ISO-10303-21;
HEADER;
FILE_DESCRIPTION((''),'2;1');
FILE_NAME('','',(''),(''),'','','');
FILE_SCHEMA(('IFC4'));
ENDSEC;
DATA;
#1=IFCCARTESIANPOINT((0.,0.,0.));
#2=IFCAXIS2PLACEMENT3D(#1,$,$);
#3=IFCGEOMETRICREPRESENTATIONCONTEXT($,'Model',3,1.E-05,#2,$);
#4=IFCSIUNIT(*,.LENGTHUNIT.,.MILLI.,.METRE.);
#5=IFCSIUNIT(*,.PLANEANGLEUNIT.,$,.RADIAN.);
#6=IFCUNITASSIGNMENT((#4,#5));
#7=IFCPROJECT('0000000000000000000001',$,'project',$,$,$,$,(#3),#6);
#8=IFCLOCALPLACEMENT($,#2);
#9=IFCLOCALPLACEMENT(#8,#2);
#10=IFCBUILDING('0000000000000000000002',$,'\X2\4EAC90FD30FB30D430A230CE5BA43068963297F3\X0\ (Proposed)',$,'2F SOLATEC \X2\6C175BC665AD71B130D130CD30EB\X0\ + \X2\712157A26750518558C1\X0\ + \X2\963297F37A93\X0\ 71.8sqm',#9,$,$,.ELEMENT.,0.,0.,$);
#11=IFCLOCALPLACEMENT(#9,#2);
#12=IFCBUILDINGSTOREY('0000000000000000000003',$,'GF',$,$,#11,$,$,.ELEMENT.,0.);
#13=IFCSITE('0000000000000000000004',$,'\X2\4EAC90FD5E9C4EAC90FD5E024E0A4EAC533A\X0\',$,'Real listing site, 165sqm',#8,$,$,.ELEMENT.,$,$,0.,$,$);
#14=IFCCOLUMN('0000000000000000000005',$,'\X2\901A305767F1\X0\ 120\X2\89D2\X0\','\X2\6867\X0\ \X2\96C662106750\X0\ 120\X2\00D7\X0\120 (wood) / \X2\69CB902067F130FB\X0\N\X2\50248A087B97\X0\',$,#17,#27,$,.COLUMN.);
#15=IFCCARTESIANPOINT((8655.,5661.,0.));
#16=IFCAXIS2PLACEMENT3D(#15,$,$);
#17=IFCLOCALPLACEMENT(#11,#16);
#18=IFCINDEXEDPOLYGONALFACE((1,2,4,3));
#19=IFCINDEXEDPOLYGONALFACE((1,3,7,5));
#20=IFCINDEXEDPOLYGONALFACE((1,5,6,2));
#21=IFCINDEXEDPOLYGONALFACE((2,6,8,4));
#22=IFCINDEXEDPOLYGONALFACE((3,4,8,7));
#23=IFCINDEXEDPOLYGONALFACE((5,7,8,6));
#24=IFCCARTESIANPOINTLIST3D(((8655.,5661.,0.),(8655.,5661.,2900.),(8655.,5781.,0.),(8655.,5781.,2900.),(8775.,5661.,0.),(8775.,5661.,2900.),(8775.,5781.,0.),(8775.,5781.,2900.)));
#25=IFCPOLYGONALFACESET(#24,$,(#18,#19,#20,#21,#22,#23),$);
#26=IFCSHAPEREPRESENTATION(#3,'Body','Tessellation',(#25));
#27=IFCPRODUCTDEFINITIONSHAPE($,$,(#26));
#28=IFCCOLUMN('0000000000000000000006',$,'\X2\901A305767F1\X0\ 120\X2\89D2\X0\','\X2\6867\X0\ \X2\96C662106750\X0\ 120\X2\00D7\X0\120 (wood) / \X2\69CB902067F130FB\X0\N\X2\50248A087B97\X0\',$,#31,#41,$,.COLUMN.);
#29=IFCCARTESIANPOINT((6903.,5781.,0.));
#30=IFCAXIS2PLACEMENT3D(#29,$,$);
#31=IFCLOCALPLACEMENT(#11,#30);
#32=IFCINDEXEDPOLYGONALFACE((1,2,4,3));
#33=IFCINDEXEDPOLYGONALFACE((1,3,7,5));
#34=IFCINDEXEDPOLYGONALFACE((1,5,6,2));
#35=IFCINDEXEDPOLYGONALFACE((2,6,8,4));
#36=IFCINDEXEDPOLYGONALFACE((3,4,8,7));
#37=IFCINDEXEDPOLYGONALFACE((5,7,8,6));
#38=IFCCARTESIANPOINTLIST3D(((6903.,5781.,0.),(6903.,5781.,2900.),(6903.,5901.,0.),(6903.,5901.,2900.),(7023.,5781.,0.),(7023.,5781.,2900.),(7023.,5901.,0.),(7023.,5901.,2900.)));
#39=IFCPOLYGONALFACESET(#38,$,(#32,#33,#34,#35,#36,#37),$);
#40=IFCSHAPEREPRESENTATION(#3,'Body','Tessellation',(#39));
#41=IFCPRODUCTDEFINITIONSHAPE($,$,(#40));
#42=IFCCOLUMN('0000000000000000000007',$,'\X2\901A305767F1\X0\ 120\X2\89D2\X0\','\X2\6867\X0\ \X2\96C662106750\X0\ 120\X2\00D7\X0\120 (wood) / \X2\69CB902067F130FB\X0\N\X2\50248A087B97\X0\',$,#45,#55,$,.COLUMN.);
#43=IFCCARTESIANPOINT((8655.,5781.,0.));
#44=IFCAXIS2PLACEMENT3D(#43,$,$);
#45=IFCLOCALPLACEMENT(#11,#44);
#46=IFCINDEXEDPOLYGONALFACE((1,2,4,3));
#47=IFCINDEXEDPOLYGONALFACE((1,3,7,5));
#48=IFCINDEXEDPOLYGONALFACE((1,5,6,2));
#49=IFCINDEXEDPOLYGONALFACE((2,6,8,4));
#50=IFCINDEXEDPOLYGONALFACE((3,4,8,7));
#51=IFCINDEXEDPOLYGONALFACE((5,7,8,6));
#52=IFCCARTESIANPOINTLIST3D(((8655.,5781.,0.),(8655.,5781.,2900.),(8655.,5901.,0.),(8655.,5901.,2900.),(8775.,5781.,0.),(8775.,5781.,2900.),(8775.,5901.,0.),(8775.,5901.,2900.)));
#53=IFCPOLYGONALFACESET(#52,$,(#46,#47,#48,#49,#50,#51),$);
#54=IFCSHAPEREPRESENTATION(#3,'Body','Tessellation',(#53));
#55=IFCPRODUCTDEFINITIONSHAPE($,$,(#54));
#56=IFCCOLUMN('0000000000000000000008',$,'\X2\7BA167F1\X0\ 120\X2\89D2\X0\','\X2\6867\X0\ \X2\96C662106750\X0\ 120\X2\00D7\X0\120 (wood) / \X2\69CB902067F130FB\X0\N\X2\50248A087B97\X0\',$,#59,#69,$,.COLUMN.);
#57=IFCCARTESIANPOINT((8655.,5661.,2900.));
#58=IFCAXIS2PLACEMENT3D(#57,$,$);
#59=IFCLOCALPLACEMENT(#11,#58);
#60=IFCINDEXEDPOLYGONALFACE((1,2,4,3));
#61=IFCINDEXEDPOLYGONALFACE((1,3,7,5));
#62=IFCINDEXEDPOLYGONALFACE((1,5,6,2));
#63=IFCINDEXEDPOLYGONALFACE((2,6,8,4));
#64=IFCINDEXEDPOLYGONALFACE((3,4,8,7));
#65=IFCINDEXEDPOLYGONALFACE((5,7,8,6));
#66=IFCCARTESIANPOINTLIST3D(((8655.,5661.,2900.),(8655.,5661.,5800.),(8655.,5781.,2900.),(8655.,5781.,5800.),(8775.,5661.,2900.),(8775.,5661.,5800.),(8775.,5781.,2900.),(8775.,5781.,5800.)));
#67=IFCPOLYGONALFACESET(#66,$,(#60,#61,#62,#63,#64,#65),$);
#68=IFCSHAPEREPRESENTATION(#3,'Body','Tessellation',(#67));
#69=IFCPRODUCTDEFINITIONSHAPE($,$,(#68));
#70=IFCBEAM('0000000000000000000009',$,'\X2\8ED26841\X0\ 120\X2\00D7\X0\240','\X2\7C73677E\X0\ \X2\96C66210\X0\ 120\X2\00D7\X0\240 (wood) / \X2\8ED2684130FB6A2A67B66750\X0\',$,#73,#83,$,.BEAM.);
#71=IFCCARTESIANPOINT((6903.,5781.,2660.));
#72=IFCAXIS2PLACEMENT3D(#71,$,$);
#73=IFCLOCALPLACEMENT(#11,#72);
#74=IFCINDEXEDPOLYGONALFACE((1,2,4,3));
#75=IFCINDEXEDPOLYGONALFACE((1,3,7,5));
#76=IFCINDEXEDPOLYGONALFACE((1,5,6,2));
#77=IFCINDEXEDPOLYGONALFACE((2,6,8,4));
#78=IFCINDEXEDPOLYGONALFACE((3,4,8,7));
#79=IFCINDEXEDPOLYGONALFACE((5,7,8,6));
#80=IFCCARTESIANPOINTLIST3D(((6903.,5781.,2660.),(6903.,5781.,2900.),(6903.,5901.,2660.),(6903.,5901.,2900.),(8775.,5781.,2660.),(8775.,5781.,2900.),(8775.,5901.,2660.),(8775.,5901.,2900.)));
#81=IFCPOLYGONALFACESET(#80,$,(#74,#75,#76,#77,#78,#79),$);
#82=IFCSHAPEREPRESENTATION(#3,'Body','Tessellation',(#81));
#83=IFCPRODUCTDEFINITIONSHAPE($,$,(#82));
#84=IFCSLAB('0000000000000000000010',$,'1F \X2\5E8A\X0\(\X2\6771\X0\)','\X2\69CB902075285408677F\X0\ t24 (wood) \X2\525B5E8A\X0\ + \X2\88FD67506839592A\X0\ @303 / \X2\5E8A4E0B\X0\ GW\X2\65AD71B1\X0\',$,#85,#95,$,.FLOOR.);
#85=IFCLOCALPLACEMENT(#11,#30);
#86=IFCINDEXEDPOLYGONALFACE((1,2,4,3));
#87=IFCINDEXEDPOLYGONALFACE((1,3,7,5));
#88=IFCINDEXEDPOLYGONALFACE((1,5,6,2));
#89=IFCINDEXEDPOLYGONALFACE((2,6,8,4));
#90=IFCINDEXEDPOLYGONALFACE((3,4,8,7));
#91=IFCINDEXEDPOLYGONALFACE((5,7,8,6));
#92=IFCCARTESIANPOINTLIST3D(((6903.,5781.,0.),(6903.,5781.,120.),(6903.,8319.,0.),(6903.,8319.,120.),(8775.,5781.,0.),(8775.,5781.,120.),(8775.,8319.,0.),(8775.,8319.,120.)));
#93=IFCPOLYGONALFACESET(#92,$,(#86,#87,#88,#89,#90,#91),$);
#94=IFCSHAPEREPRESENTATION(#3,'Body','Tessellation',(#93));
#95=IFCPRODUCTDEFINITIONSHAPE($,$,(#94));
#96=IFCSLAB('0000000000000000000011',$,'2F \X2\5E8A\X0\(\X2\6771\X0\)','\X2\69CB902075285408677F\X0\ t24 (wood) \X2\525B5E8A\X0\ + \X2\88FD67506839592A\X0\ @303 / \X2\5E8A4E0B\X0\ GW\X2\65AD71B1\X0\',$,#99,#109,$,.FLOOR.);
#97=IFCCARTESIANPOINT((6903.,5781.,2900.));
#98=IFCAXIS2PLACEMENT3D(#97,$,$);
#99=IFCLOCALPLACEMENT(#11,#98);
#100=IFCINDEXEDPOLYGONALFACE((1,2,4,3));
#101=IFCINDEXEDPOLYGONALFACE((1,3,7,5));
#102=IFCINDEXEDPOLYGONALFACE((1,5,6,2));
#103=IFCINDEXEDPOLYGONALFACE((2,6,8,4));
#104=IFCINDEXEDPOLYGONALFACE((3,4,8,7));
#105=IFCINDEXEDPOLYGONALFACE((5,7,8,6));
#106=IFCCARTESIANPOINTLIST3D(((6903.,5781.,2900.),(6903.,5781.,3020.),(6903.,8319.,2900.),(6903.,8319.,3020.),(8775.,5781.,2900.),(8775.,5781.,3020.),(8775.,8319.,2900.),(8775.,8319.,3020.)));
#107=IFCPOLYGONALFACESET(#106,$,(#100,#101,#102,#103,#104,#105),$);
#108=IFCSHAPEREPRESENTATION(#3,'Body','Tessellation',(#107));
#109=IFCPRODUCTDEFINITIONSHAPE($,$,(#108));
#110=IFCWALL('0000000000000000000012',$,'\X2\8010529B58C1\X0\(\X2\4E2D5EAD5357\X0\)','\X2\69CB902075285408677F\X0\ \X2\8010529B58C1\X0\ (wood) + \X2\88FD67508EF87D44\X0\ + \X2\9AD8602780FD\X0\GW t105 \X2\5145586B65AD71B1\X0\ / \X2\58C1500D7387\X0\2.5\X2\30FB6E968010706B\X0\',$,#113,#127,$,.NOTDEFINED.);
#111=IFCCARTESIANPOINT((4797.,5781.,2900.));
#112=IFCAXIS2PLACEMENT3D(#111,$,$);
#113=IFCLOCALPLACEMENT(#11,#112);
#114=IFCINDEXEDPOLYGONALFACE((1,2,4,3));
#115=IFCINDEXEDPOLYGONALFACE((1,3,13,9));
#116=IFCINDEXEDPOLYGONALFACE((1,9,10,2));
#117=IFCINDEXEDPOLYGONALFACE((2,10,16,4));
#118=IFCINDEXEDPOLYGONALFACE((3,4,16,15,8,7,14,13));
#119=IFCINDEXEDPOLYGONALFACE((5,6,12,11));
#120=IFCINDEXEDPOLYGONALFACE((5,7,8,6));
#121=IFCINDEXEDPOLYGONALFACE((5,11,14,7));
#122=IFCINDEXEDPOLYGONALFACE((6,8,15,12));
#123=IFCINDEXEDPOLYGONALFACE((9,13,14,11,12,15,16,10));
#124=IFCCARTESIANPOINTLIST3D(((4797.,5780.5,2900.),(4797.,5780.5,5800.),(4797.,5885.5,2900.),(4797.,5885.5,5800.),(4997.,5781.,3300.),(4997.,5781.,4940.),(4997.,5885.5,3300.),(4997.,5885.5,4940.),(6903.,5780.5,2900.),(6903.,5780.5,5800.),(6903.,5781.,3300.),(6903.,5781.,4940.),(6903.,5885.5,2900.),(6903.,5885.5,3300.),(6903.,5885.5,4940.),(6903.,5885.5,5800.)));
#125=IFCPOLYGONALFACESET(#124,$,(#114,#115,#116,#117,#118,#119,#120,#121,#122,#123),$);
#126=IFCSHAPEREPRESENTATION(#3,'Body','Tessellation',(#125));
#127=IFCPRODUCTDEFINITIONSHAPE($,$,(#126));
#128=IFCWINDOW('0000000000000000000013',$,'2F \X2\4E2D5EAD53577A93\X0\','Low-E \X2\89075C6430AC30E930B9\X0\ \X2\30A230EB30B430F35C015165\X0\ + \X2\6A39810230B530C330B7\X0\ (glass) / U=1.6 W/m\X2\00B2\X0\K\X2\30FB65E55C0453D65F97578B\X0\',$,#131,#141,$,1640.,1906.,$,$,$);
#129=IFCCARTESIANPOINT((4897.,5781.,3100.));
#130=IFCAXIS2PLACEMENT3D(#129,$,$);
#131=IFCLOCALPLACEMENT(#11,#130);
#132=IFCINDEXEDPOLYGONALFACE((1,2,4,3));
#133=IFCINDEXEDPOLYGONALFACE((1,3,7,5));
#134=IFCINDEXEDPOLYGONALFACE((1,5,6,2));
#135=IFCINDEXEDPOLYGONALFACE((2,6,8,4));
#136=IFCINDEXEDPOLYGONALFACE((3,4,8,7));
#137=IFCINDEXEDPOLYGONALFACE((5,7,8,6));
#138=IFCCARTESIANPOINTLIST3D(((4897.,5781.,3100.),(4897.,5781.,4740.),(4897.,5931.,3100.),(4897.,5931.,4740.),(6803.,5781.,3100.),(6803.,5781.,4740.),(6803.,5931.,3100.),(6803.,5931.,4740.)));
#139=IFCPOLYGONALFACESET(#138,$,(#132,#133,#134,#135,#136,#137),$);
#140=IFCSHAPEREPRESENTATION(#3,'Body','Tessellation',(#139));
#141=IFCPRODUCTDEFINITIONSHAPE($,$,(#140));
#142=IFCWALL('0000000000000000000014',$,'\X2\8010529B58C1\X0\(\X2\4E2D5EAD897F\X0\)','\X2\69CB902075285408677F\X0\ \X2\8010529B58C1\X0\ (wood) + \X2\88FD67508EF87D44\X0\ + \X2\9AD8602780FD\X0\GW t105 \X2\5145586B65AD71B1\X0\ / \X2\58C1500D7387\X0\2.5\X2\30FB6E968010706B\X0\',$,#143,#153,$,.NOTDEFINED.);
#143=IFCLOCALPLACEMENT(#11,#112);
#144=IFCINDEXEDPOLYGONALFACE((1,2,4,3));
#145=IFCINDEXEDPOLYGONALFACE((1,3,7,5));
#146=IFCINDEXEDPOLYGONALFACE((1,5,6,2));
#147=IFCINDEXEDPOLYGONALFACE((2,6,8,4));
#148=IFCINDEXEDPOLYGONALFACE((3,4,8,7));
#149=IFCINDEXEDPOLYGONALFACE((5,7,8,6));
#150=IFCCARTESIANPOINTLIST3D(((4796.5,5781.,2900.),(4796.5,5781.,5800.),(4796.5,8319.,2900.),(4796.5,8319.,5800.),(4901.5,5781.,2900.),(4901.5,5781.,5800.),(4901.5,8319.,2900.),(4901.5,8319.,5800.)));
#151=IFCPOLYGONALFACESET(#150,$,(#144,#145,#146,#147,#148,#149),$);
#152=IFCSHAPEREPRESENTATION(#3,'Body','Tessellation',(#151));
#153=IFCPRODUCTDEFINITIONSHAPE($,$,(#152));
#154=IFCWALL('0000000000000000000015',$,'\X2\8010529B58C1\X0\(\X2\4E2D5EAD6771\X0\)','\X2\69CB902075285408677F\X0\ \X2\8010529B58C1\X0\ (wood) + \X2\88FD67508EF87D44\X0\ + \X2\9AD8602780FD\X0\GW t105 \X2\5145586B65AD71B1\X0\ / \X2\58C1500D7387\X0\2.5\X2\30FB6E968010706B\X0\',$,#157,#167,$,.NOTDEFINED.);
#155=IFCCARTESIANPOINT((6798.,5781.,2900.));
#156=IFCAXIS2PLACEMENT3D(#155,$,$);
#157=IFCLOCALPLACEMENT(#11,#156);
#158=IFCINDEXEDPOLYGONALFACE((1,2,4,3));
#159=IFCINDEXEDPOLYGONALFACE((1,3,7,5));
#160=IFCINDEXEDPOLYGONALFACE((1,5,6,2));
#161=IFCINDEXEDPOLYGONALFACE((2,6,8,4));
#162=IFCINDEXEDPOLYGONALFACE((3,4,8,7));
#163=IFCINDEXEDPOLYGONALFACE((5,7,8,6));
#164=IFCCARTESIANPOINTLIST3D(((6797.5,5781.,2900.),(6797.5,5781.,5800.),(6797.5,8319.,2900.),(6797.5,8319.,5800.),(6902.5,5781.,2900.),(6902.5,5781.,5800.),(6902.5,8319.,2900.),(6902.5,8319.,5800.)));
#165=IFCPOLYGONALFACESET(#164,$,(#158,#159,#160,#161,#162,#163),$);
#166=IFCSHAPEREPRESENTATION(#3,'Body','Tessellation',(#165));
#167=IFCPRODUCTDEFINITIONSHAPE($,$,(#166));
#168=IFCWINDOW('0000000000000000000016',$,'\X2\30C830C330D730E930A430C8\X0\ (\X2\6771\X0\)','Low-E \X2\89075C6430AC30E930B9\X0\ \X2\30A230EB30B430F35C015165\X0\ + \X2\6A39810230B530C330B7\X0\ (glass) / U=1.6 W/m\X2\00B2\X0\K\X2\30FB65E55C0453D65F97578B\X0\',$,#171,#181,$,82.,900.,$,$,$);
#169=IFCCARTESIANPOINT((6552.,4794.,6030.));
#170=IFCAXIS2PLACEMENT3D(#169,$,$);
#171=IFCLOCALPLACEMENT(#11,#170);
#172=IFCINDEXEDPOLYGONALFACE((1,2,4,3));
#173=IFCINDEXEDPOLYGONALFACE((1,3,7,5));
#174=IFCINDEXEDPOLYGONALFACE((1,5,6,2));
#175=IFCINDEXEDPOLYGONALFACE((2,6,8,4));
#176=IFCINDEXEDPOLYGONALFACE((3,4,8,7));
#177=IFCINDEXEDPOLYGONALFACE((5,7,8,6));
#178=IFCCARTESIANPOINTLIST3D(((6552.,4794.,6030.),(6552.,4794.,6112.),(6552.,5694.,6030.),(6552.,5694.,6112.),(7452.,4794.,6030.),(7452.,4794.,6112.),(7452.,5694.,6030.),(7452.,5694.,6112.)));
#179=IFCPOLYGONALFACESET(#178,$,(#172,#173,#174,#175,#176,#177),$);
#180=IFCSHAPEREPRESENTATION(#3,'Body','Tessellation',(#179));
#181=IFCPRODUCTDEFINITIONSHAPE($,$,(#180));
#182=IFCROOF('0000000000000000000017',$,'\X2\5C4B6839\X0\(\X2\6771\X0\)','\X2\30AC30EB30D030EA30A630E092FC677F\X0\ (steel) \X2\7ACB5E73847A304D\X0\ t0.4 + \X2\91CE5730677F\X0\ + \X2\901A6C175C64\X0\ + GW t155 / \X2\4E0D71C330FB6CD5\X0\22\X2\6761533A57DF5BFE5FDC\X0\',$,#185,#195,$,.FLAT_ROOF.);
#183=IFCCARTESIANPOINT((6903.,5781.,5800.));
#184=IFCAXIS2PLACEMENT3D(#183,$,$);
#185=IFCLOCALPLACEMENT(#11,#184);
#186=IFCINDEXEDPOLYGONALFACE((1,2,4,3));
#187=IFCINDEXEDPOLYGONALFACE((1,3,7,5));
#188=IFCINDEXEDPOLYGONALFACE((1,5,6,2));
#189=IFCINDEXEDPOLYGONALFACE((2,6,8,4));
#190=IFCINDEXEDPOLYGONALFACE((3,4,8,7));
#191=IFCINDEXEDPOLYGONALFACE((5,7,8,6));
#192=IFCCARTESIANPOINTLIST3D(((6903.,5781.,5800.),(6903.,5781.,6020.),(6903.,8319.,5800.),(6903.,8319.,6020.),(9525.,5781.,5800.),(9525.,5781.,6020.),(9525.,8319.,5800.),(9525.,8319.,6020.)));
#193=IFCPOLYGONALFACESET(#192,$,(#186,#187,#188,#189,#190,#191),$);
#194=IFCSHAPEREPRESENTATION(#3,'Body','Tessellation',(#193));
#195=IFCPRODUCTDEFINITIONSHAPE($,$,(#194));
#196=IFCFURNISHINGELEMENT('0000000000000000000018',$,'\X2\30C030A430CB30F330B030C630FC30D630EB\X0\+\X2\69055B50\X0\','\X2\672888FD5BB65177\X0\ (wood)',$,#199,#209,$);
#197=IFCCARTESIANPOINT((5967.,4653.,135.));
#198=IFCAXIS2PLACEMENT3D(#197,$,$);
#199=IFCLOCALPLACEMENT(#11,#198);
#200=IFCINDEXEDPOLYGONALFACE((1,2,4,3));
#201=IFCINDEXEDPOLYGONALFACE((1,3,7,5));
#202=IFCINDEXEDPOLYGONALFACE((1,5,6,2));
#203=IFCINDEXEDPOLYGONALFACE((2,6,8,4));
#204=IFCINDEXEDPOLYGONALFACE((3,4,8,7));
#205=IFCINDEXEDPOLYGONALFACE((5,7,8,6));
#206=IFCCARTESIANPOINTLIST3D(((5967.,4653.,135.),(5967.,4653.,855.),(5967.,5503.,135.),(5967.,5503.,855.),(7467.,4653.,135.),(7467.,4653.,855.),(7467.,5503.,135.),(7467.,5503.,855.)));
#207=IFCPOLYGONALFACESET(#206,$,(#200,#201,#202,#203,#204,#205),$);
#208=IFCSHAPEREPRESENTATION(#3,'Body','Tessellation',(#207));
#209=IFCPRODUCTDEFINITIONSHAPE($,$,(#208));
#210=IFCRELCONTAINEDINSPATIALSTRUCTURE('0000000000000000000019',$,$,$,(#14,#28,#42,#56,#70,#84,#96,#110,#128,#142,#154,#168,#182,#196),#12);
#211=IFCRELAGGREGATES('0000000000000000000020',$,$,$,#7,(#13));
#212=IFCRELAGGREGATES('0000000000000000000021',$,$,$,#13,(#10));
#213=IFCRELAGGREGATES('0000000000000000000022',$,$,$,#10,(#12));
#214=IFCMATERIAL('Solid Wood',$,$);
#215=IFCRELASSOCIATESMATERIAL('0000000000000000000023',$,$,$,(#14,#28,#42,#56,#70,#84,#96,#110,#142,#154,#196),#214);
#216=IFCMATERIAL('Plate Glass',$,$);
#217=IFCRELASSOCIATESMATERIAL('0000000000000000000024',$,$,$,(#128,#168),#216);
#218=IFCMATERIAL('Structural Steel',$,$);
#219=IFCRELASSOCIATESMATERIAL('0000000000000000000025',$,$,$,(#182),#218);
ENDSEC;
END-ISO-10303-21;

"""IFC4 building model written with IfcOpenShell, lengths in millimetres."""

from ifc_helpers import new_model, si_unit, frame, frame_2d, origin, place, context, project, spatial, rectangle, extrude, material, element, fill, save


model = new_model("IFC4")

# Units and contexts
model_context = context("Model", 3, precision=1e-05, world=origin())
ifc_project = project(units=[si_unit("LENGTHUNIT", "METRE", prefix="MILLI"), si_unit("PLANEANGLEUNIT", "RADIAN")], contexts=[model_context])

# Site, building, storey
site_placement = place(None, origin())
site = spatial("IfcSite", under=ifc_project, at=site_placement, Name="京都府京都市上京区", ObjectType="Real listing site, 165sqm", CompositionType="ELEMENT", RefElevation=0.0)
building_placement = place(site_placement, origin())
building = spatial("IfcBuilding", under=site, at=building_placement, Name="京都・ピアノ室と防音 (Proposed)", ObjectType="2F SOLATEC 気密断熱パネル + 無垢材内壁 + 防音窓 71.8sqm", CompositionType="ELEMENT", ElevationOfRefHeight=0.0, ElevationOfTerrain=0.0)
storey_placement = place(building_placement, origin())
storey = spatial("IfcBuildingStorey", under=building, at=storey_placement, Name="GF", CompositionType="ELEMENT", Elevation=0.0)

# Columns
ifc_material_1 = material(Name="Solid Wood")
column_1_placement = place(storey_placement, frame((8655.0, 5661.0, 0.0)))
element("IfcColumn", 1, at=column_1_placement, inside=storey, material=ifc_material_1, Name="通し柱 120角", Description="桧 集成材 120×120 (wood) / 構造柱・N値計算", PredefinedType="COLUMN", context=model_context, shape_type="SweptSolid", body=[
    extrude(rectangle(XDim=120.0, YDim=120.0, at=frame_2d((60.0, 60.0))), frame((8655.0, 5661.0, 0.0)), (0.0, 0.0, 1.0), 2900.0),
])
column_2_placement = place(storey_placement, frame((6903.0, 5781.0, 0.0)))
element("IfcColumn", 2, at=column_2_placement, inside=storey, material=ifc_material_1, Name="通し柱 120角", Description="桧 集成材 120×120 (wood) / 構造柱・N値計算", PredefinedType="COLUMN", context=model_context, shape_type="SweptSolid", body=[
    extrude(rectangle(XDim=120.0, YDim=120.0, at=frame_2d((60.0, 60.0))), frame((6903.0, 5781.0, 0.0)), (0.0, 0.0, 1.0), 2900.0),
])
column_3_placement = place(storey_placement, frame((8655.0, 5781.0, 0.0)))
element("IfcColumn", 3, at=column_3_placement, inside=storey, material=ifc_material_1, Name="通し柱 120角", Description="桧 集成材 120×120 (wood) / 構造柱・N値計算", PredefinedType="COLUMN", context=model_context, shape_type="SweptSolid", body=[
    extrude(rectangle(XDim=120.0, YDim=120.0, at=frame_2d((60.0, 60.0))), frame((8655.0, 5781.0, 0.0)), (0.0, 0.0, 1.0), 2900.0),
])
column_4_placement = place(storey_placement, frame((8655.0, 5661.0, 2900.0)))
element("IfcColumn", 4, at=column_4_placement, inside=storey, material=ifc_material_1, Name="管柱 120角", Description="桧 集成材 120×120 (wood) / 構造柱・N値計算", PredefinedType="COLUMN", context=model_context, shape_type="SweptSolid", body=[
    extrude(rectangle(XDim=120.0, YDim=120.0, at=frame_2d((60.0, 60.0))), frame((8655.0, 5661.0, 2900.0)), (0.0, 0.0, 1.0), 2900.0),
])

# Beam
beam_1_placement = place(storey_placement, frame((6903.0, 5781.0, 2660.0)))
element("IfcBeam", 5, at=beam_1_placement, inside=storey, material=ifc_material_1, Name="軒桁 120×240", Description="米松 集成 120×240 (wood) / 軒桁・横架材", PredefinedType="BEAM", context=model_context, shape_type="SweptSolid", body=[
    extrude(rectangle(XDim=1872.0, YDim=120.0, at=frame_2d((936.0, 60.0))), frame((6903.0, 5781.0, 2660.0)), (0.0, 0.0, 1.0), 240.0),
])

# Slabs
slab_1_placement = place(storey_placement, frame((6903.0, 5781.0, 0.0)))
element("IfcSlab", 6, at=slab_1_placement, inside=storey, material=ifc_material_1, Name="1F 床(東)", Description="構造用合板 t24 (wood) 剛床 + 製材根太 @303 / 床下 GW断熱", PredefinedType="FLOOR", context=model_context, shape_type="SweptSolid", body=[
    extrude(rectangle(XDim=1872.0, YDim=2538.0, at=frame_2d((936.0, 1269.0))), frame((6903.0, 5781.0, 0.0)), (0.0, 0.0, 1.0), 120.0),
])
slab_2_placement = place(storey_placement, frame((6903.0, 5781.0, 2900.0)))
element("IfcSlab", 7, at=slab_2_placement, inside=storey, material=ifc_material_1, Name="2F 床(東)", Description="構造用合板 t24 (wood) 剛床 + 製材根太 @303 / 床下 GW断熱", PredefinedType="FLOOR", context=model_context, shape_type="SweptSolid", body=[
    extrude(rectangle(XDim=1872.0, YDim=2538.0, at=frame_2d((936.0, 1269.0))), frame((6903.0, 5781.0, 2900.0)), (0.0, 0.0, 1.0), 120.0),
])

# Wall, opening, window
wall_1_placement = place(storey_placement, frame((4797.0, 5781.0, 2900.0)))
wall_1 = element("IfcWall", 8, at=wall_1_placement, inside=storey, material=ifc_material_1, Name="耐力壁(中庭南)", Description="構造用合板 耐力壁 (wood) + 製材軸組 + 高性能GW t105 充填断熱 / 壁倍率2.5・準耐火", PredefinedType="NOTDEFINED", context=model_context, shape_type="SweptSolid", body=[
    extrude(rectangle(XDim=2106.0, YDim=105.0, at=frame_2d((1053.0, 52.0))), frame((4797.0, 5781.0, 2900.0)), (0.0, 0.0, 1.0), 2900.0),
])
opening_placement = place(storey_placement, frame((4897.0, 5781.0, 3100.0)))
opening = element("IfcOpeningElement", 9, at=opening_placement, cuts=wall_1, PredefinedType="NOTDEFINED", context=model_context, shape_type="SweptSolid", body=[
    extrude(rectangle(XDim=1906.0, YDim=150.0, at=frame_2d((953.0, 75.0))), frame((4897.0, 5781.0, 3100.0)), (0.0, 0.0, 1.0), 1640.0),
])
ifc_material_2 = material(Name="Plate Glass")
window_1_placement = place(storey_placement, frame((4897.0, 5781.0, 3100.0)))
window_1 = element("IfcWindow", 10, at=window_1_placement, inside=storey, material=ifc_material_2, Name="2F 中庭南窓", Description="Low-E 複層ガラス アルゴン封入 + 樹脂サッシ (glass) / U=1.6 W/m²K・日射取得型", OverallHeight=1640.0, OverallWidth=1906.0, context=model_context, shape_type="SweptSolid", body=[
    extrude(rectangle(XDim=1906.0, YDim=150.0, at=frame_2d((953.0, 75.0))), frame((4897.0, 5781.0, 3100.0)), (0.0, 0.0, 1.0), 1640.0),
])
fill(opening, window_1)

# Walls
wall_2_placement = place(storey_placement, frame((4797.0, 5781.0, 2900.0)))
element("IfcWall", 11, at=wall_2_placement, inside=storey, material=ifc_material_1, Name="耐力壁(中庭西)", Description="構造用合板 耐力壁 (wood) + 製材軸組 + 高性能GW t105 充填断熱 / 壁倍率2.5・準耐火", PredefinedType="NOTDEFINED", context=model_context, shape_type="SweptSolid", body=[
    extrude(rectangle(XDim=105.0, YDim=2538.0, at=frame_2d((52.0, 1269.0))), frame((4797.0, 5781.0, 2900.0)), (0.0, 0.0, 1.0), 2900.0),
])
wall_3_placement = place(storey_placement, frame((6798.0, 5781.0, 2900.0)))
element("IfcWall", 12, at=wall_3_placement, inside=storey, material=ifc_material_1, Name="耐力壁(中庭東)", Description="構造用合板 耐力壁 (wood) + 製材軸組 + 高性能GW t105 充填断熱 / 壁倍率2.5・準耐火", PredefinedType="NOTDEFINED", context=model_context, shape_type="SweptSolid", body=[
    extrude(rectangle(XDim=105.0, YDim=2538.0, at=frame_2d((52.0, 1269.0))), frame((6798.0, 5781.0, 2900.0)), (0.0, 0.0, 1.0), 2900.0),
])

# Window
window_2_placement = place(storey_placement, frame((6552.0, 4794.0, 6030.0)))
element("IfcWindow", 13, at=window_2_placement, inside=storey, material=ifc_material_2, Name="トップライト (東)", Description="Low-E 複層ガラス アルゴン封入 + 樹脂サッシ (glass) / U=1.6 W/m²K・日射取得型", OverallHeight=82.0, OverallWidth=900.0, context=model_context, shape_type="SweptSolid", body=[
    extrude(rectangle(XDim=900.0, YDim=900.0, at=frame_2d((450.0, 450.0))), frame((6552.0, 4794.0, 6030.0)), (0.0, 0.0, 1.0), 82.0),
])

# Roof
ifc_material_3 = material(Name="Structural Steel")
for number, where, name in (
    (14, (6903.0, 5781.0, 5800.0), "屋根(東)"),
):
    element("IfcRoof", number, at=place(storey_placement, frame(where)), inside=storey, material=ifc_material_3, Name=name, Description="ガルバリウム鋼板 (steel) 立平葺き t0.4 + 野地板 + 通気層 + GW t155 / 不燃・法22条区域対応", PredefinedType="FLAT_ROOF", context=model_context, shape_type="SweptSolid", body=[
        extrude(rectangle(XDim=2622.0, YDim=2538.0, at=frame_2d((1311.0, 1269.0))), frame((6903.0, 5781.0, 5800.0)), (0.0, 0.0, 1.0), 220.0),
    ])

# Furnishing element
furnishing_1_placement = place(storey_placement, frame((5967.0, 4653.0, 135.0)))
element("IfcFurnishingElement", 15, at=furnishing_1_placement, inside=storey, material=ifc_material_1, Name="ダイニングテーブル+椅子", Description="木製家具 (wood)", context=model_context, shape_type="SweptSolid", body=[
    extrude(rectangle(XDim=1500.0, YDim=850.0, at=frame_2d((750.0, 425.0))), frame((5967.0, 4653.0, 135.0)), (0.0, 0.0, 1.0), 720.0),
])

save(model, "model.ifc")
